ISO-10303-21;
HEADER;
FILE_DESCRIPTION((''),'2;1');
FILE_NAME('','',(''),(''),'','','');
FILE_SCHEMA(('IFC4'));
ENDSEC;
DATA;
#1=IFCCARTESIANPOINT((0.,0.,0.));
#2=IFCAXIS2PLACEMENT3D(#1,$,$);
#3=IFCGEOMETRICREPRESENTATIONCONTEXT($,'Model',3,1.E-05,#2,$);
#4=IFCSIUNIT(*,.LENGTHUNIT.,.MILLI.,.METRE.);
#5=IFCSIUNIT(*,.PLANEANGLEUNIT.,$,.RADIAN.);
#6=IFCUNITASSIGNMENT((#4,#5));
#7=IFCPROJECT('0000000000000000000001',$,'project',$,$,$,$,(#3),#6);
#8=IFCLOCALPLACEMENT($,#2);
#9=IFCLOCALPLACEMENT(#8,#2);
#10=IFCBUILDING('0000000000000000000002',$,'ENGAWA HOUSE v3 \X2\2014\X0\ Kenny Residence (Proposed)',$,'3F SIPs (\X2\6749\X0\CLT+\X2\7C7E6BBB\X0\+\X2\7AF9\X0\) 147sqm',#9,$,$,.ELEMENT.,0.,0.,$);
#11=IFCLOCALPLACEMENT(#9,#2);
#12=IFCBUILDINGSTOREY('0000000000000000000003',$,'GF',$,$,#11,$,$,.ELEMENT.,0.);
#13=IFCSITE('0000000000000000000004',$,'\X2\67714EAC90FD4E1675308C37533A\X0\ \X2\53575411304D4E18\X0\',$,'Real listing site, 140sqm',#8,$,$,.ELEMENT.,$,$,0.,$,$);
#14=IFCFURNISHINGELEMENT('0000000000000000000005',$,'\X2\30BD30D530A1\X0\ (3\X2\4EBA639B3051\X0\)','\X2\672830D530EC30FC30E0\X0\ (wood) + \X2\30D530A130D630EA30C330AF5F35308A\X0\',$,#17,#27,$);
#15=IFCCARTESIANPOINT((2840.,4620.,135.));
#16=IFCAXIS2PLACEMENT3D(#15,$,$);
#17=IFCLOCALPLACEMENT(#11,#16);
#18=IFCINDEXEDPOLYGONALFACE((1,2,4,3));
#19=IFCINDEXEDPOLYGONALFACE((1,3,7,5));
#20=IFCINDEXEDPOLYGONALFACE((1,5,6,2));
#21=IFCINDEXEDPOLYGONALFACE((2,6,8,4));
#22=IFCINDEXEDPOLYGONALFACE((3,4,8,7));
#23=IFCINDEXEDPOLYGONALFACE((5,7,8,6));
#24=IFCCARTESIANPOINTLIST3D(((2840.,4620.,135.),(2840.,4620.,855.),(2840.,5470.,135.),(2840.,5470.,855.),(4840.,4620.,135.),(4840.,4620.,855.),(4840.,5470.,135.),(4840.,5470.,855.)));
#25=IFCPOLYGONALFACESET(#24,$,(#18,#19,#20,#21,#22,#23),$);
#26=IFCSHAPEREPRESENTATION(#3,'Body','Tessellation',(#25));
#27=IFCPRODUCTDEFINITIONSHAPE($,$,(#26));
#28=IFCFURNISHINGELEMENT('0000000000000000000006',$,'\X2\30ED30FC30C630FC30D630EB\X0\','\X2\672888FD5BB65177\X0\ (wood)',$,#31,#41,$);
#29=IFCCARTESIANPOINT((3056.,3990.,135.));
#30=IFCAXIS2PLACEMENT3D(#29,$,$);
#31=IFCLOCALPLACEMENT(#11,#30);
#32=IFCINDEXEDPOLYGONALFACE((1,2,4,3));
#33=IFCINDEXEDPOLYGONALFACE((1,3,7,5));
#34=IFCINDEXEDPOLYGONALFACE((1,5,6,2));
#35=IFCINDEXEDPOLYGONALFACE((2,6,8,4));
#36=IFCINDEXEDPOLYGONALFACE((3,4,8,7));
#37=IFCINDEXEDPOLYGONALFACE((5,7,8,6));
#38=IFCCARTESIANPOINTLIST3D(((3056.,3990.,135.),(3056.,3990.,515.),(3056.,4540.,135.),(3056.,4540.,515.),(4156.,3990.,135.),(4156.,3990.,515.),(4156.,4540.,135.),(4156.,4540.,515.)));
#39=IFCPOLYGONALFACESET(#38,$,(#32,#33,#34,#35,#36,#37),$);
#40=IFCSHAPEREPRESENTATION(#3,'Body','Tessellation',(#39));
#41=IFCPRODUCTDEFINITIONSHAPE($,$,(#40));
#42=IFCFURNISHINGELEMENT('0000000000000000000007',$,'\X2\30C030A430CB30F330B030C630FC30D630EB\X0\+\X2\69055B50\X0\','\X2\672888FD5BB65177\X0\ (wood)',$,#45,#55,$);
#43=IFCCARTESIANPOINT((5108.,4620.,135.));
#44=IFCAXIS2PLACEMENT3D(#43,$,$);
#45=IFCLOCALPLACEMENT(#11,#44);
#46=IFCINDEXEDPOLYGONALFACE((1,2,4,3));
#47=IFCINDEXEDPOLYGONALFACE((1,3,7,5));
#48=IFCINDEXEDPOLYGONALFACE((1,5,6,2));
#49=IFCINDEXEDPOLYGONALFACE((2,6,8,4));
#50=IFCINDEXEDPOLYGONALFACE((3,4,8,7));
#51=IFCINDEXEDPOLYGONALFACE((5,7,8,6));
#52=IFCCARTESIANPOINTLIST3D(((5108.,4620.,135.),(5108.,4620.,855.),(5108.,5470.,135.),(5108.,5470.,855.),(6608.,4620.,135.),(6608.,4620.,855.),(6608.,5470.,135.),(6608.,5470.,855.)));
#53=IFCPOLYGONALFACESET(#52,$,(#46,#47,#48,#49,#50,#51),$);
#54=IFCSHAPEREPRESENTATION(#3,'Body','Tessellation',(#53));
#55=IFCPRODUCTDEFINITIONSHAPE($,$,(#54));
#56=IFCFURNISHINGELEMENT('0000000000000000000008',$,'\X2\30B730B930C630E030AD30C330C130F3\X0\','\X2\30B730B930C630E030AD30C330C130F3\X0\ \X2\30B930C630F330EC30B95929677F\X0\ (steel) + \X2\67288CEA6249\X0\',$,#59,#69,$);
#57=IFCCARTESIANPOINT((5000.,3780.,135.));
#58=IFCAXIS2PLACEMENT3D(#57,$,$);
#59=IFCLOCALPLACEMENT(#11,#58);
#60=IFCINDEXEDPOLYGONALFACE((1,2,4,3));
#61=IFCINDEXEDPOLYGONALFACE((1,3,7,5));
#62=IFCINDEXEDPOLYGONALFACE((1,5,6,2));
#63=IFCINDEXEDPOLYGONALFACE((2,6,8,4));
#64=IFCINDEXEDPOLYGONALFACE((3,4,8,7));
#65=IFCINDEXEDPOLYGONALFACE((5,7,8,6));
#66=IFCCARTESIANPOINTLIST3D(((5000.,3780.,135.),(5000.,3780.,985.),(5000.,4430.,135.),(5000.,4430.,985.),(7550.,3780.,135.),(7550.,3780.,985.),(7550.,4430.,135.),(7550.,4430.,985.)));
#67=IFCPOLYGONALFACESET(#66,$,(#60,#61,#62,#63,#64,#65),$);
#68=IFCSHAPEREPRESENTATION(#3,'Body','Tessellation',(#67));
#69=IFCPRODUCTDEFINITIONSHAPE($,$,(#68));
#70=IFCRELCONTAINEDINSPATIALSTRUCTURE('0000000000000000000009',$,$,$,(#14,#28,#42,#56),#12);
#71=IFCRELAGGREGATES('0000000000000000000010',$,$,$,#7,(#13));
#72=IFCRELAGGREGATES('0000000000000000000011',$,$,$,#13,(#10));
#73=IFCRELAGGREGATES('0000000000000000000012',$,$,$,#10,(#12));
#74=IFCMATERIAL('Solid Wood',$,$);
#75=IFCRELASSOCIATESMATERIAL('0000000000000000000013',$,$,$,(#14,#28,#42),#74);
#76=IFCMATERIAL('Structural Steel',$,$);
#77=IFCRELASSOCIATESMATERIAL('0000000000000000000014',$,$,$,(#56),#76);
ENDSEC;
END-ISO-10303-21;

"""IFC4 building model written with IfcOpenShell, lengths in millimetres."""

from ifc_helpers import new_model, si_unit, frame, frame_2d, origin, place, context, project, spatial, rectangle, extrude, material, element, save


model = new_model("IFC4")

# Units and contexts
model_context = context("Model", 3, precision=1e-05, world=origin())
ifc_project = project(units=[si_unit("LENGTHUNIT", "METRE", prefix="MILLI"), si_unit("PLANEANGLEUNIT", "RADIAN")], contexts=[model_context])

# Site, building, storey
site_placement = place(None, origin())
site = spatial("IfcSite", under=ifc_project, at=site_placement, Name="東京都世田谷区 南向き丘", ObjectType="Real listing site, 140sqm", CompositionType="ELEMENT", RefElevation=0.0)
building_placement = place(site_placement, origin())
building = spatial("IfcBuilding", under=site, at=building_placement, Name="ENGAWA HOUSE v3 — Kenny Residence (Proposed)", ObjectType="3F SIPs (杉CLT+籾殻+竹) 147sqm", CompositionType="ELEMENT", ElevationOfRefHeight=0.0, ElevationOfTerrain=0.0)
storey_placement = place(building_placement, origin())
storey = spatial("IfcBuildingStorey", under=building, at=storey_placement, Name="GF", CompositionType="ELEMENT", Elevation=0.0)

# Shared definitions
ifc_material_1 = material(Name="Solid Wood")

# Furnishing elements
furnishing_1_placement = place(storey_placement, frame((2840.0, 4620.0, 135.0)))
element("IfcFurnishingElement", 1, at=furnishing_1_placement, inside=storey, material=ifc_material_1, Name="ソファ (3人掛け)", Description="木フレーム (wood) + ファブリック張り", context=model_context, shape_type="SweptSolid", body=[
    extrude(rectangle(XDim=2000.0, YDim=850.0, at=frame_2d((1000.0, 425.0))), frame((2840.0, 4620.0, 135.0)), (0.0, 0.0, 1.0), 720.0),
])
furnishing_2_placement = place(storey_placement, frame((3056.0, 3990.0, 135.0)))
element("IfcFurnishingElement", 2, at=furnishing_2_placement, inside=storey, material=ifc_material_1, Name="ローテーブル", Description="木製家具 (wood)", context=model_context, shape_type="SweptSolid", body=[
    extrude(rectangle(XDim=1100.0, YDim=550.0, at=frame_2d((550.0, 275.0))), frame((3056.0, 3990.0, 135.0)), (0.0, 0.0, 1.0), 380.0),
])
furnishing_3_placement = place(storey_placement, frame((5108.0, 4620.0, 135.0)))
element("IfcFurnishingElement", 3, at=furnishing_3_placement, inside=storey, material=ifc_material_1, Name="ダイニングテーブル+椅子", Description="木製家具 (wood)", context=model_context, shape_type="SweptSolid", body=[
    extrude(rectangle(XDim=1500.0, YDim=850.0, at=frame_2d((750.0, 425.0))), frame((5108.0, 4620.0, 135.0)), (0.0, 0.0, 1.0), 720.0),
])
ifc_material_2 = material(Name="Structural Steel")
furnishing_4_placement = place(storey_placement, frame((5000.0, 3780.0, 135.0)))
element("IfcFurnishingElement", 4, at=furnishing_4_placement, inside=storey, material=ifc_material_2, Name="システムキッチン", Description="システムキッチン ステンレス天板 (steel) + 木質扉", context=model_context, shape_type="SweptSolid", body=[
    extrude(rectangle(XDim=2550.0, YDim=650.0, at=frame_2d((1275.0, 325.0))), frame((5000.0, 3780.0, 135.0)), (0.0, 0.0, 1.0), 850.0),
])

save(model, "model.ifc")
